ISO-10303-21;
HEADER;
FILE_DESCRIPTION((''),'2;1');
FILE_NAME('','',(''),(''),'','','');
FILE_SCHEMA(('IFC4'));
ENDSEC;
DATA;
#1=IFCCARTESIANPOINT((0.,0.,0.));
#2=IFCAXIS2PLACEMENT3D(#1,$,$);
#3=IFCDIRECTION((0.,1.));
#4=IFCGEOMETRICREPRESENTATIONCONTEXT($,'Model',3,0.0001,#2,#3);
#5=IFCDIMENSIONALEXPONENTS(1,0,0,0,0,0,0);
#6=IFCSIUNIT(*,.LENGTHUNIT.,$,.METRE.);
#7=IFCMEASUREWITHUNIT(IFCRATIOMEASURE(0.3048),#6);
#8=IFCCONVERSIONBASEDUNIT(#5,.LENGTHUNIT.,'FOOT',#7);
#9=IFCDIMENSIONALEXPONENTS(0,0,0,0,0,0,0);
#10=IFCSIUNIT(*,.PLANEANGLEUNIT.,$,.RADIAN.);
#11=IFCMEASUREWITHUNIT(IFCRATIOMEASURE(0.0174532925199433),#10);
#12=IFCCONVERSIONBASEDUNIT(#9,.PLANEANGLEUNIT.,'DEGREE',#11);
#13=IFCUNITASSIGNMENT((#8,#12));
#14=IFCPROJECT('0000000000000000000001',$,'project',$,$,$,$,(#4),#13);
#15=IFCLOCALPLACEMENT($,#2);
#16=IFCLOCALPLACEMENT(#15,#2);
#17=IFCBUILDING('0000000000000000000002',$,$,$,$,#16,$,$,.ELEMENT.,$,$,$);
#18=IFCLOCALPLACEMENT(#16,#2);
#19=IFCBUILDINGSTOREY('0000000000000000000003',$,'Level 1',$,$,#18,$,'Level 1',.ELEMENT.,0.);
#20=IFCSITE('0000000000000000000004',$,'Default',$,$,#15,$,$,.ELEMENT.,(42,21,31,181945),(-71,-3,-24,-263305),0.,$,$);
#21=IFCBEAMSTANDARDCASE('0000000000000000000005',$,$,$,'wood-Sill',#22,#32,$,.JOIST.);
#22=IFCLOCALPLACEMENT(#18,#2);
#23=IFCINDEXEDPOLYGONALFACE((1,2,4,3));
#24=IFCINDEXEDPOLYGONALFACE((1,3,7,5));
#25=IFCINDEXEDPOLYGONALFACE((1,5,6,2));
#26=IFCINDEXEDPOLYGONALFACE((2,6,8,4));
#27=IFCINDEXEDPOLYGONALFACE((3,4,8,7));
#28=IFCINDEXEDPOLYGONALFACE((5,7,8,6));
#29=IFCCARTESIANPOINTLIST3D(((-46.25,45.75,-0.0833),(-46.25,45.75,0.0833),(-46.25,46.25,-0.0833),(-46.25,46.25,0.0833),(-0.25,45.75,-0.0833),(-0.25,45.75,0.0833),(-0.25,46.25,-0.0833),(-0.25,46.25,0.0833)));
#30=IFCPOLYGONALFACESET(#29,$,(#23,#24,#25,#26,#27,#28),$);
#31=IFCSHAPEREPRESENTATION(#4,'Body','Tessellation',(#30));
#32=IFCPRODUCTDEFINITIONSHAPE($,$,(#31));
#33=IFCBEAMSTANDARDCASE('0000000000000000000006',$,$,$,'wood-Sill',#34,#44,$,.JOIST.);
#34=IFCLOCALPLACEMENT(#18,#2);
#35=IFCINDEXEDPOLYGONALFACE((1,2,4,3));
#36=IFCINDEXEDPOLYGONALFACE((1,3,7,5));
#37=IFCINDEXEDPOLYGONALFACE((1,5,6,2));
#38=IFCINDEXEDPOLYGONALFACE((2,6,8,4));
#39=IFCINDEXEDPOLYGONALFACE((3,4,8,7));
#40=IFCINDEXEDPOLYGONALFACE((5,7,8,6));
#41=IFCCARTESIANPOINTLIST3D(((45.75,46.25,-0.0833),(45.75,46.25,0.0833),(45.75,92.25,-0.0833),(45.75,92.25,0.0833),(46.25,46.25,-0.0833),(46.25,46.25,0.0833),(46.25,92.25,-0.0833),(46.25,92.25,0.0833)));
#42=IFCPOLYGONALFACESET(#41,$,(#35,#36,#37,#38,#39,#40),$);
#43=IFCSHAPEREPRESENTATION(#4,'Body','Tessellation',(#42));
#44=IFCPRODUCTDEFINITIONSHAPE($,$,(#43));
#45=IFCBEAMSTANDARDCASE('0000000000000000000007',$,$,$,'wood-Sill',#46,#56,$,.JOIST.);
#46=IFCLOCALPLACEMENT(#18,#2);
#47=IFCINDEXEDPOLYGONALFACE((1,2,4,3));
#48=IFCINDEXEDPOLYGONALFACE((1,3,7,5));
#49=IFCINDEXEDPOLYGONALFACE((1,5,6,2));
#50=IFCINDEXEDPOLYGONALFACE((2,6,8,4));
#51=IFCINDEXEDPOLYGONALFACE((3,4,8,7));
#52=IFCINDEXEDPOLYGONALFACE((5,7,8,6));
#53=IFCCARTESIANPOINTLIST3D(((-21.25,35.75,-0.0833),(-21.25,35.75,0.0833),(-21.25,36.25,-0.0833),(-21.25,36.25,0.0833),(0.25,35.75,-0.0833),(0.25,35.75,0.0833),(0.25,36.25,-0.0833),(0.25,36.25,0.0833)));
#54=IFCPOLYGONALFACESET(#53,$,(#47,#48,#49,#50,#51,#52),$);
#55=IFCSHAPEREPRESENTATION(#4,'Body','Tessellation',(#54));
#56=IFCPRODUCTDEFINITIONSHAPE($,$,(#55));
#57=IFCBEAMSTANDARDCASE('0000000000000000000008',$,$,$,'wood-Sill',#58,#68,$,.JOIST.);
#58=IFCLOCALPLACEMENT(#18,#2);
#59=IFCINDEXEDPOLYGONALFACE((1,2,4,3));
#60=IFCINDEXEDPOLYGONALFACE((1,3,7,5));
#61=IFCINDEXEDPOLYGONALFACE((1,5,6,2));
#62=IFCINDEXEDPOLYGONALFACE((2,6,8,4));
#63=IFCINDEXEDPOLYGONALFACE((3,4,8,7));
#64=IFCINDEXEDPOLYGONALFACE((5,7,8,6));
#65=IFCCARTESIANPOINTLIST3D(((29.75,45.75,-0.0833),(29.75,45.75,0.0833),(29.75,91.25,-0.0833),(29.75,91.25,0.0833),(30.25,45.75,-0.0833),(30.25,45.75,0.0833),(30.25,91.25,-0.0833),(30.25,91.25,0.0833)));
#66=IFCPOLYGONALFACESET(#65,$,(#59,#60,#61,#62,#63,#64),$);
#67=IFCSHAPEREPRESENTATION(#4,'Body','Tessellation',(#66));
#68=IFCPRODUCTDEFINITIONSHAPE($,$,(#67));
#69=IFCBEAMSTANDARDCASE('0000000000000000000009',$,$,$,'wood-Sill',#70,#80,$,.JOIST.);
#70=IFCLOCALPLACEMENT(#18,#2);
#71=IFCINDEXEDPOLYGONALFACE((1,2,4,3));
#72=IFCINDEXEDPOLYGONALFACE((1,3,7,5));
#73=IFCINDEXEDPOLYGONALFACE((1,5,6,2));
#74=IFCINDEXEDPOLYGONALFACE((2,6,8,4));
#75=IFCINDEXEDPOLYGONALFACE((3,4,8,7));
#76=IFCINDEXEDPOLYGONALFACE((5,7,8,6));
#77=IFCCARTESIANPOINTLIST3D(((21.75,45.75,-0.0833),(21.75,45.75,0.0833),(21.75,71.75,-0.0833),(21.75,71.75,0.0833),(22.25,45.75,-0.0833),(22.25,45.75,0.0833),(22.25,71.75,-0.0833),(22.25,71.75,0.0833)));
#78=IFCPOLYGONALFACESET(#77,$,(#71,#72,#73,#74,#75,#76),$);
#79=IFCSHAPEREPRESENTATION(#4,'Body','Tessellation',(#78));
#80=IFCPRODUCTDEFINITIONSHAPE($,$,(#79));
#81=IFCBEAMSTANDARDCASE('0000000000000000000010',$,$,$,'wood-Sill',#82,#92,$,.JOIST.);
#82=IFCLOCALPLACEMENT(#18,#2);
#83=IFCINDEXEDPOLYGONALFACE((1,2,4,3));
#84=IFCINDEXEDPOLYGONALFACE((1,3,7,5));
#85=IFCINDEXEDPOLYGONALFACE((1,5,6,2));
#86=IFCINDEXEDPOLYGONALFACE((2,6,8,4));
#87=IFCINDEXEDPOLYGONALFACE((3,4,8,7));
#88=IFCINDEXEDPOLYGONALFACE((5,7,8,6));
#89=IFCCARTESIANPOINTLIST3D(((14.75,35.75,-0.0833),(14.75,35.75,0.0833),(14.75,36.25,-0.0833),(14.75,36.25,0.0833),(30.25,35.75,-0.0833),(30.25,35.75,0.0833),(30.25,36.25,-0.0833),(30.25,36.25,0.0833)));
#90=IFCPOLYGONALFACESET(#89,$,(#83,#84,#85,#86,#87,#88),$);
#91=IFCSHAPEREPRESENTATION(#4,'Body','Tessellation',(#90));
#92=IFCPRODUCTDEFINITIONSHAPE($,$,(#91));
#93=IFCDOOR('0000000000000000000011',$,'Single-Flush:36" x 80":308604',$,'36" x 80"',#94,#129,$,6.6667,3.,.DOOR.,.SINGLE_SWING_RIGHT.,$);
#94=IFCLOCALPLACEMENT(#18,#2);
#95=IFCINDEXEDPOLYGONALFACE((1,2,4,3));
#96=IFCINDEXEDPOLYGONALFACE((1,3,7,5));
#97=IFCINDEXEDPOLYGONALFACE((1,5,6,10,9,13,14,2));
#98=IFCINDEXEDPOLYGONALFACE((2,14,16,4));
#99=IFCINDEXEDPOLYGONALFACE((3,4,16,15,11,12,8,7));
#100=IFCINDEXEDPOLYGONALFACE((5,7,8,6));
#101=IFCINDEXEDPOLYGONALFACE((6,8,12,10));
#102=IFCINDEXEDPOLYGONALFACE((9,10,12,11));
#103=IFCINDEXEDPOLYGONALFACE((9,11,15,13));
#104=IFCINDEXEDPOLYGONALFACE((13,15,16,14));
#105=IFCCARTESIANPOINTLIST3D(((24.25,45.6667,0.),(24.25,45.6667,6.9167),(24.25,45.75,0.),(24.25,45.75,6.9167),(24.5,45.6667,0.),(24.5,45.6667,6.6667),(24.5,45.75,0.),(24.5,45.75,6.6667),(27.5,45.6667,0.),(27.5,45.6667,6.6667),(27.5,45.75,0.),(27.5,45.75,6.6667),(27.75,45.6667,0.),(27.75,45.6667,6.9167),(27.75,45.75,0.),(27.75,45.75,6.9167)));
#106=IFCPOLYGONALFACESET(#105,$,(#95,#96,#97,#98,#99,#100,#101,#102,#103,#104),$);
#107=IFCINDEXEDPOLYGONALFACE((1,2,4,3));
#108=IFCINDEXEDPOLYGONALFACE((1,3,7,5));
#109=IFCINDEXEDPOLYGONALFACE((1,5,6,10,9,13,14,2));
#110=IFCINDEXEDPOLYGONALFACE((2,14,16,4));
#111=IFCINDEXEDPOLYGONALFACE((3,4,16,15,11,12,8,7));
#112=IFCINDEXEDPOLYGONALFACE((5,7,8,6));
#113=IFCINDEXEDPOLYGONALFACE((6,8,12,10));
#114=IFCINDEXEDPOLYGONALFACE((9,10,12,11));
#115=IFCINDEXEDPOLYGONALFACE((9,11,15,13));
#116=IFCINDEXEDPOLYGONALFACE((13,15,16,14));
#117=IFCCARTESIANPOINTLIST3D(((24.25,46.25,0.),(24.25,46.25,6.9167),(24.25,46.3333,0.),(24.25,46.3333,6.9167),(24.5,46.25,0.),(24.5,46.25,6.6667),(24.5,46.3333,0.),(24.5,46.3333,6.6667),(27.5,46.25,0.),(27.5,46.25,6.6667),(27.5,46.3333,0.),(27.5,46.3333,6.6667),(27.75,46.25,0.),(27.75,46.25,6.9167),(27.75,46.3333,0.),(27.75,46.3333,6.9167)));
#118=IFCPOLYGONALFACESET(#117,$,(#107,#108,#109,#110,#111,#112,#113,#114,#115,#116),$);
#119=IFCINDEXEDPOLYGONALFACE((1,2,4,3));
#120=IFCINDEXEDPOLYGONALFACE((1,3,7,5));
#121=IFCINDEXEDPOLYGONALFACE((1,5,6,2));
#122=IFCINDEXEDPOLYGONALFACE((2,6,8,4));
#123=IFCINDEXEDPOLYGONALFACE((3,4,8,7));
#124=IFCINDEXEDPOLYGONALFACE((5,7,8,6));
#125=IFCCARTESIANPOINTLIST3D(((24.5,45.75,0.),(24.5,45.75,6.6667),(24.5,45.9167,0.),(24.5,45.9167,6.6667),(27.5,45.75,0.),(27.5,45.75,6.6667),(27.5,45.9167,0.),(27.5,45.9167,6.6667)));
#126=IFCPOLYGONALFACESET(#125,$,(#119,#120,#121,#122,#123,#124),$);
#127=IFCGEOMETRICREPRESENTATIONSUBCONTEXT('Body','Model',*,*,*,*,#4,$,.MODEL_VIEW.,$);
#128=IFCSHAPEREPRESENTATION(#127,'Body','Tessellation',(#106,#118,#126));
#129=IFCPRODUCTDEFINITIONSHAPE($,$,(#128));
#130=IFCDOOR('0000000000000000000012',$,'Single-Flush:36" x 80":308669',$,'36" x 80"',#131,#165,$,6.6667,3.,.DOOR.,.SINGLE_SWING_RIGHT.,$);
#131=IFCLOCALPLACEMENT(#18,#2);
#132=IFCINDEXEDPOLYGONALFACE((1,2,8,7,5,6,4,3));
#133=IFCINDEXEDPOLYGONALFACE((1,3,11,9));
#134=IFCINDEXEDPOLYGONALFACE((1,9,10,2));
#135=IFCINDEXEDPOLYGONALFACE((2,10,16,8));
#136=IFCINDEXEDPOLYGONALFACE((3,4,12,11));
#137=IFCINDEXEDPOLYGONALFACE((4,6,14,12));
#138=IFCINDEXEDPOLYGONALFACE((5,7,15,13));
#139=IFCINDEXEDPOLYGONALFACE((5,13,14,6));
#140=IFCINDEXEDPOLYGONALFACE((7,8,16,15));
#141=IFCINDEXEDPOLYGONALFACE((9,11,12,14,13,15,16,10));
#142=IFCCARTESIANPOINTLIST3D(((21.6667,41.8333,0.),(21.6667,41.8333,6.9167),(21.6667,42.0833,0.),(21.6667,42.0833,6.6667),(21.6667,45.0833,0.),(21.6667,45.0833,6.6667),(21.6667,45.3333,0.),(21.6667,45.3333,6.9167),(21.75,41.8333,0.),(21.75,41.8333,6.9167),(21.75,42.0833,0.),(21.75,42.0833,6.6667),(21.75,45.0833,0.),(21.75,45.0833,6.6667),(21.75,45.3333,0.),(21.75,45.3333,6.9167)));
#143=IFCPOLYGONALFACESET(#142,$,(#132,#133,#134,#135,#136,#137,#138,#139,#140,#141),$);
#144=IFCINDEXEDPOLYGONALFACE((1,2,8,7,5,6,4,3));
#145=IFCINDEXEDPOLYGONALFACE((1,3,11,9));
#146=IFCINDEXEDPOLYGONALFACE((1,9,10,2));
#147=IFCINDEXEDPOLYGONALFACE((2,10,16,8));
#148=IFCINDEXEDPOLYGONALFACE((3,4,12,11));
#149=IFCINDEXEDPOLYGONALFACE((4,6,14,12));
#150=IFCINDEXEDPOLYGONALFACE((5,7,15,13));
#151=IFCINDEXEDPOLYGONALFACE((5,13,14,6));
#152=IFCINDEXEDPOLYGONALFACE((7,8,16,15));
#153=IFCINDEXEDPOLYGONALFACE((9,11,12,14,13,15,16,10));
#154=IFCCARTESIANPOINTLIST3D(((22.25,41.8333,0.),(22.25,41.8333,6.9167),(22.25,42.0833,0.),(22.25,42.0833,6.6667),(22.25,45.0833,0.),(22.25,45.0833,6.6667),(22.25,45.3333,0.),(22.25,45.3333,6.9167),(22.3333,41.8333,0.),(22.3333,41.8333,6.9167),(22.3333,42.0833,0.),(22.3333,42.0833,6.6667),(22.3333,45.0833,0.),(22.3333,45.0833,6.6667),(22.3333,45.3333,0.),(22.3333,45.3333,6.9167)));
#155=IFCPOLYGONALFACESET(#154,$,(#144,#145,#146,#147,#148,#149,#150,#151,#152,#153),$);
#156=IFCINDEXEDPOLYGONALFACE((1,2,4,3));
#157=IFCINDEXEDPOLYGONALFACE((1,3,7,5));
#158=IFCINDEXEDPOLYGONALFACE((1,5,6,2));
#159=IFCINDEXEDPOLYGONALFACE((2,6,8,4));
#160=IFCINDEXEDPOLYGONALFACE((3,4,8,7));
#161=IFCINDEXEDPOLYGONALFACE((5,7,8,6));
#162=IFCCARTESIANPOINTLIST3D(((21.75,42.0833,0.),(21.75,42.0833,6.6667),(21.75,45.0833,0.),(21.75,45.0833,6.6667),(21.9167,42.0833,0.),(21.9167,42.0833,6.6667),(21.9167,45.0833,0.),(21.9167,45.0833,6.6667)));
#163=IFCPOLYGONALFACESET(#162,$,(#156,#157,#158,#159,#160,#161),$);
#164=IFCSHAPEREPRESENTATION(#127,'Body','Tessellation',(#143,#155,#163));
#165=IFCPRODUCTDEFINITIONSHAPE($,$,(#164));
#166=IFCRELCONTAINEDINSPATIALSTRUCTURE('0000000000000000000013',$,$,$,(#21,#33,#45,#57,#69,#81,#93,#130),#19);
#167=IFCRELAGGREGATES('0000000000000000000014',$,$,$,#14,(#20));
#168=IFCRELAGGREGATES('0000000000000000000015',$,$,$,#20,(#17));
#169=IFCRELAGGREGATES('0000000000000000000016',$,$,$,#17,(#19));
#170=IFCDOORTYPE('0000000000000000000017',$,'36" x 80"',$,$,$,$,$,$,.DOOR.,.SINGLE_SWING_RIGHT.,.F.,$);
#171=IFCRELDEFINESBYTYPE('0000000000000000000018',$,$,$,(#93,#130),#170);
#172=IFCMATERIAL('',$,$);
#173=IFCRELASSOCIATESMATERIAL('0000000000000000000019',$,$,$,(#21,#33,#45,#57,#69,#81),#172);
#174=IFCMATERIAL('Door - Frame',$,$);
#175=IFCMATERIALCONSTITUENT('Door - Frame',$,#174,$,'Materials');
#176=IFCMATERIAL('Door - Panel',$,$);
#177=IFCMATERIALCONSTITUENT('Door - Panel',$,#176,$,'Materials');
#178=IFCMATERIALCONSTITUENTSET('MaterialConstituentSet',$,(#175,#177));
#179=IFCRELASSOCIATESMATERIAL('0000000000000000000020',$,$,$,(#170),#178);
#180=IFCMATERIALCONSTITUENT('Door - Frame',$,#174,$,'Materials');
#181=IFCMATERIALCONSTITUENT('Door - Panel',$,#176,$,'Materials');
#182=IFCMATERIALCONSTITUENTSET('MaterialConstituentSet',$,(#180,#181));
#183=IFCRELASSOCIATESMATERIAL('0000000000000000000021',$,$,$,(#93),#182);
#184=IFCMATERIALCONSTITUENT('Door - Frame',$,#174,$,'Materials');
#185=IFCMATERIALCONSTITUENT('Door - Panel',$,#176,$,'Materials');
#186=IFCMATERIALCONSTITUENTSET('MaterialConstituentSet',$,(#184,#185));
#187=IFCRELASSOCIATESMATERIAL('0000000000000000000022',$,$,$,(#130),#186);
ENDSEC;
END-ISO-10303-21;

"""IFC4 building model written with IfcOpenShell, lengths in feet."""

from ifc_helpers import new_model, entity, si_unit, converted_unit, direction, frame, origin, origin_with_axes, origin_2d_with_axis, place, context, subcontext, project, spatial, polyline, rectangle, outline, extrude, source, transform, mapped, material, constituent, constituent_set, type_object, type_shapes, element, save


model = new_model("IFC4")

# Units and contexts
model_context = context("Model", 3, precision=0.0001, world=origin(), true_north=direction((0.0, 1.0)))
body_context = subcontext(model_context, "Body", "Model", "MODEL_VIEW")
ifc_project = project(units=[converted_unit("LENGTHUNIT", "FOOT", entity("IfcRatioMeasure", 0.3048), si_unit("LENGTHUNIT", "METRE"), dimensions=[1, 0, 0, 0, 0, 0, 0]), converted_unit("PLANEANGLEUNIT", "DEGREE", entity("IfcRatioMeasure", 0.0174532925199433), si_unit("PLANEANGLEUNIT", "RADIAN"), dimensions=[0, 0, 0, 0, 0, 0, 0])], contexts=[model_context])

# Site, building, storey
site_placement = place(None, origin())
site = spatial("IfcSite", under=ifc_project, at=site_placement, Name="Default", CompositionType="ELEMENT", RefLatitude=(42, 21, 31, 181945), RefLongitude=(-71, -3, -24, -263305), RefElevation=0.0)
building_placement = place(site_placement, origin())
building = spatial("IfcBuilding", under=site, at=building_placement, CompositionType="ELEMENT")
storey_placement = place(building_placement, origin())
storey = spatial("IfcBuildingStorey", under=building, at=storey_placement, Name="Level 1", LongName="Level 1", CompositionType="ELEMENT", Elevation=0.0)

# Beams
ifc_material_1 = material(Name="")
placement_1 = place(storey_placement, frame((-0.25, 46.0, 0.0)))
beam_1_placement = place(placement_1, frame((0.0, 0.0, 0.0), z_axis=(-1.0, 0.0, 0.0), x_axis=(0.0, 0.0, 1.0)))
element("IfcBeamStandardCase", 1, at=beam_1_placement, inside=storey, material=ifc_material_1, ObjectType="wood-Sill", PredefinedType="JOIST", context=model_context, shape_type="SweptSolid", body=[
    extrude(rectangle(XDim=0.1667, YDim=0.5), origin_with_axes(), (0.0, 0.0, 1.0), 46.0),
])
placement_2 = place(storey_placement, frame((46.0, 46.25, 0.0), z_axis=(0.0, 0.0, 1.0), x_axis=(0.0, -1.0, 0.0)))
beam_2_placement = place(placement_2, frame((0.0, 0.0, 0.0), z_axis=(-1.0, 0.0, 0.0), x_axis=(0.0, 0.0, 1.0)))
element("IfcBeamStandardCase", 2, at=beam_2_placement, inside=storey, material=ifc_material_1, ObjectType="wood-Sill", PredefinedType="JOIST", context=model_context, shape_type="SweptSolid", body=[
    extrude(rectangle(XDim=0.1667, YDim=0.5), origin_with_axes(), (0.0, 0.0, 1.0), 46.0),
])
placement_3 = place(storey_placement, frame((0.25, 36.0, 0.0)))
beam_3_placement = place(placement_3, frame((0.0, 0.0, 0.0), z_axis=(-1.0, 0.0, 0.0), x_axis=(0.0, 0.0, 1.0)))
element("IfcBeamStandardCase", 3, at=beam_3_placement, inside=storey, material=ifc_material_1, ObjectType="wood-Sill", PredefinedType="JOIST", context=model_context, shape_type="SweptSolid", body=[
    extrude(rectangle(XDim=0.1667, YDim=0.5), origin_with_axes(), (0.0, 0.0, 1.0), 21.5),
])
placement_4 = place(storey_placement, frame((30.0, 45.75, 0.0), z_axis=(0.0, 0.0, 1.0), x_axis=(0.0, -1.0, 0.0)))
beam_4_placement = place(placement_4, frame((0.0, 0.0, 0.0), z_axis=(-1.0, 0.0, 0.0), x_axis=(0.0, 0.0, 1.0)))
element("IfcBeamStandardCase", 4, at=beam_4_placement, inside=storey, material=ifc_material_1, ObjectType="wood-Sill", PredefinedType="JOIST", context=model_context, shape_type="SweptSolid", body=[
    extrude(rectangle(XDim=0.1667, YDim=0.5), origin_with_axes(), (0.0, 0.0, 1.0), 45.5),
])
placement_5 = place(storey_placement, frame((22.0, 45.75, 0.0), z_axis=(0.0, 0.0, 1.0), x_axis=(0.0, -1.0, 0.0)))
beam_5_placement = place(placement_5, frame((0.0, 0.0, 0.0), z_axis=(-1.0, 0.0, 0.0), x_axis=(0.0, 0.0, 1.0)))
element("IfcBeamStandardCase", 5, at=beam_5_placement, inside=storey, material=ifc_material_1, ObjectType="wood-Sill", PredefinedType="JOIST", context=model_context, shape_type="SweptSolid", body=[
    extrude(rectangle(XDim=0.1667, YDim=0.5), origin_with_axes(), (0.0, 0.0, 1.0), 26.0),
])
placement_6 = place(storey_placement, frame((30.25, 36.0, 0.0)))
beam_6_placement = place(placement_6, frame((0.0, 0.0, 0.0), z_axis=(-1.0, 0.0, 0.0), x_axis=(0.0, 0.0, 1.0)))
element("IfcBeamStandardCase", 6, at=beam_6_placement, inside=storey, material=ifc_material_1, ObjectType="wood-Sill", PredefinedType="JOIST", context=model_context, shape_type="SweptSolid", body=[
    extrude(rectangle(XDim=0.1667, YDim=0.5), origin_with_axes(), (0.0, 0.0, 1.0), 15.5),
])

# Doors
ifc_material_2 = material(Name="Door - Frame")
ifc_constituent_1 = constituent(ifc_material_2, Name="Door - Frame", Category="Materials")
ifc_material_3 = material(Name="Door - Panel")
ifc_constituent_2 = constituent(ifc_material_3, Name="Door - Panel", Category="Materials")
ifc_constituent_set_1 = constituent_set(constituents=[ifc_constituent_1, ifc_constituent_2], Name="MaterialConstituentSet")
ifc_constituent_3 = constituent(ifc_material_2, Name="Door - Frame", Category="Materials")
ifc_constituent_4 = constituent(ifc_material_3, Name="Door - Panel", Category="Materials")
ifc_constituent_set_2 = constituent_set(constituents=[ifc_constituent_3, ifc_constituent_4], Name="MaterialConstituentSet")
door_type_1 = type_object("IfcDoorType", Name="36\" x 80\"", OperationType="SINGLE_SWING_RIGHT", ParameterTakesPrecedence=False, PredefinedType="DOOR", material=ifc_constituent_set_2)
shared_shape_1 = source(origin(), body_context, "Body", "SweptSolid", [
    extrude(outline(polyline([(-1.75, -3.5208), (1.75, -3.5208), (1.75, 3.3958), (1.5, 3.3958), (1.5, -3.2708), (-1.5, -3.2708), (-1.5, 3.3958), (-1.75, 3.3958), (-1.75, -3.5208)])), frame((1.5, 0.5, 3.3958), z_axis=(0.0, 1.0, 0.0), x_axis=(1.0, 0.0, 0.0)), (0.0, 0.0, 1.0), 0.0833),
    extrude(outline(polyline([(-3.5208, -1.75), (3.3958, -1.75), (3.3958, -1.5), (-3.2708, -1.5), (-3.2708, 1.5), (3.3958, 1.5), (3.3958, 1.75), (-3.5208, 1.75), (-3.5208, -1.75)])), frame((1.5, -0.0833, 3.3958), z_axis=(0.0, 1.0, 0.0), x_axis=(0.0, 0.0, -1.0)), (0.0, 0.0, 1.0), 0.0833),
    extrude(rectangle(XDim=0.1667, YDim=3.0, at=origin_2d_with_axis()), frame((1.5, 0.4167, 0.0), z_axis=(0.0, 0.0, 1.0), x_axis=(0.0, 1.0, 0.0)), (0.0, 0.0, 1.0), 6.6667),
])
type_shapes(door_type_1, [shared_shape_1])
placement_7 = place(placement_1, frame((27.75, 0.25, 0.0)))
door_1_placement = place(placement_7, frame((0.0, 0.0, 0.0), z_axis=(0.0, 0.0, 1.0), x_axis=(-1.0, 0.0, 0.0)))
element("IfcDoor", 7, at=door_1_placement, inside=storey, type_object=door_type_1, material=ifc_constituent_set_1, Name="Single-Flush:36\" x 80\":308604", ObjectType="36\" x 80\"", OperationType="SINGLE_SWING_RIGHT", OverallHeight=6.6667, OverallWidth=3.0, PredefinedType="DOOR", context=body_context, shape_type="MappedRepresentation", body=[
    mapped(shared_shape_1, transform((0.0, 0.0, 0.0), scale=1.0)),
])
ifc_constituent_5 = constituent(ifc_material_2, Name="Door - Frame", Category="Materials")
ifc_constituent_6 = constituent(ifc_material_3, Name="Door - Panel", Category="Materials")
ifc_constituent_set_3 = constituent_set(constituents=[ifc_constituent_5, ifc_constituent_6], Name="MaterialConstituentSet")
placement_8 = place(placement_5, frame((3.6667, 0.25, 0.0)))
door_2_placement = place(placement_8, frame((0.0, 0.0, 0.0), z_axis=(0.0, 0.0, 1.0), x_axis=(-1.0, 0.0, 0.0)))
element("IfcDoor", 8, at=door_2_placement, inside=storey, type_object=door_type_1, material=ifc_constituent_set_3, Name="Single-Flush:36\" x 80\":308669", ObjectType="36\" x 80\"", OperationType="SINGLE_SWING_RIGHT", OverallHeight=6.6667, OverallWidth=3.0, PredefinedType="DOOR", context=body_context, shape_type="MappedRepresentation", body=[
    mapped(shared_shape_1, transform((0.0, 0.0, 0.0), scale=1.0)),
])

save(model, "model.ifc")
